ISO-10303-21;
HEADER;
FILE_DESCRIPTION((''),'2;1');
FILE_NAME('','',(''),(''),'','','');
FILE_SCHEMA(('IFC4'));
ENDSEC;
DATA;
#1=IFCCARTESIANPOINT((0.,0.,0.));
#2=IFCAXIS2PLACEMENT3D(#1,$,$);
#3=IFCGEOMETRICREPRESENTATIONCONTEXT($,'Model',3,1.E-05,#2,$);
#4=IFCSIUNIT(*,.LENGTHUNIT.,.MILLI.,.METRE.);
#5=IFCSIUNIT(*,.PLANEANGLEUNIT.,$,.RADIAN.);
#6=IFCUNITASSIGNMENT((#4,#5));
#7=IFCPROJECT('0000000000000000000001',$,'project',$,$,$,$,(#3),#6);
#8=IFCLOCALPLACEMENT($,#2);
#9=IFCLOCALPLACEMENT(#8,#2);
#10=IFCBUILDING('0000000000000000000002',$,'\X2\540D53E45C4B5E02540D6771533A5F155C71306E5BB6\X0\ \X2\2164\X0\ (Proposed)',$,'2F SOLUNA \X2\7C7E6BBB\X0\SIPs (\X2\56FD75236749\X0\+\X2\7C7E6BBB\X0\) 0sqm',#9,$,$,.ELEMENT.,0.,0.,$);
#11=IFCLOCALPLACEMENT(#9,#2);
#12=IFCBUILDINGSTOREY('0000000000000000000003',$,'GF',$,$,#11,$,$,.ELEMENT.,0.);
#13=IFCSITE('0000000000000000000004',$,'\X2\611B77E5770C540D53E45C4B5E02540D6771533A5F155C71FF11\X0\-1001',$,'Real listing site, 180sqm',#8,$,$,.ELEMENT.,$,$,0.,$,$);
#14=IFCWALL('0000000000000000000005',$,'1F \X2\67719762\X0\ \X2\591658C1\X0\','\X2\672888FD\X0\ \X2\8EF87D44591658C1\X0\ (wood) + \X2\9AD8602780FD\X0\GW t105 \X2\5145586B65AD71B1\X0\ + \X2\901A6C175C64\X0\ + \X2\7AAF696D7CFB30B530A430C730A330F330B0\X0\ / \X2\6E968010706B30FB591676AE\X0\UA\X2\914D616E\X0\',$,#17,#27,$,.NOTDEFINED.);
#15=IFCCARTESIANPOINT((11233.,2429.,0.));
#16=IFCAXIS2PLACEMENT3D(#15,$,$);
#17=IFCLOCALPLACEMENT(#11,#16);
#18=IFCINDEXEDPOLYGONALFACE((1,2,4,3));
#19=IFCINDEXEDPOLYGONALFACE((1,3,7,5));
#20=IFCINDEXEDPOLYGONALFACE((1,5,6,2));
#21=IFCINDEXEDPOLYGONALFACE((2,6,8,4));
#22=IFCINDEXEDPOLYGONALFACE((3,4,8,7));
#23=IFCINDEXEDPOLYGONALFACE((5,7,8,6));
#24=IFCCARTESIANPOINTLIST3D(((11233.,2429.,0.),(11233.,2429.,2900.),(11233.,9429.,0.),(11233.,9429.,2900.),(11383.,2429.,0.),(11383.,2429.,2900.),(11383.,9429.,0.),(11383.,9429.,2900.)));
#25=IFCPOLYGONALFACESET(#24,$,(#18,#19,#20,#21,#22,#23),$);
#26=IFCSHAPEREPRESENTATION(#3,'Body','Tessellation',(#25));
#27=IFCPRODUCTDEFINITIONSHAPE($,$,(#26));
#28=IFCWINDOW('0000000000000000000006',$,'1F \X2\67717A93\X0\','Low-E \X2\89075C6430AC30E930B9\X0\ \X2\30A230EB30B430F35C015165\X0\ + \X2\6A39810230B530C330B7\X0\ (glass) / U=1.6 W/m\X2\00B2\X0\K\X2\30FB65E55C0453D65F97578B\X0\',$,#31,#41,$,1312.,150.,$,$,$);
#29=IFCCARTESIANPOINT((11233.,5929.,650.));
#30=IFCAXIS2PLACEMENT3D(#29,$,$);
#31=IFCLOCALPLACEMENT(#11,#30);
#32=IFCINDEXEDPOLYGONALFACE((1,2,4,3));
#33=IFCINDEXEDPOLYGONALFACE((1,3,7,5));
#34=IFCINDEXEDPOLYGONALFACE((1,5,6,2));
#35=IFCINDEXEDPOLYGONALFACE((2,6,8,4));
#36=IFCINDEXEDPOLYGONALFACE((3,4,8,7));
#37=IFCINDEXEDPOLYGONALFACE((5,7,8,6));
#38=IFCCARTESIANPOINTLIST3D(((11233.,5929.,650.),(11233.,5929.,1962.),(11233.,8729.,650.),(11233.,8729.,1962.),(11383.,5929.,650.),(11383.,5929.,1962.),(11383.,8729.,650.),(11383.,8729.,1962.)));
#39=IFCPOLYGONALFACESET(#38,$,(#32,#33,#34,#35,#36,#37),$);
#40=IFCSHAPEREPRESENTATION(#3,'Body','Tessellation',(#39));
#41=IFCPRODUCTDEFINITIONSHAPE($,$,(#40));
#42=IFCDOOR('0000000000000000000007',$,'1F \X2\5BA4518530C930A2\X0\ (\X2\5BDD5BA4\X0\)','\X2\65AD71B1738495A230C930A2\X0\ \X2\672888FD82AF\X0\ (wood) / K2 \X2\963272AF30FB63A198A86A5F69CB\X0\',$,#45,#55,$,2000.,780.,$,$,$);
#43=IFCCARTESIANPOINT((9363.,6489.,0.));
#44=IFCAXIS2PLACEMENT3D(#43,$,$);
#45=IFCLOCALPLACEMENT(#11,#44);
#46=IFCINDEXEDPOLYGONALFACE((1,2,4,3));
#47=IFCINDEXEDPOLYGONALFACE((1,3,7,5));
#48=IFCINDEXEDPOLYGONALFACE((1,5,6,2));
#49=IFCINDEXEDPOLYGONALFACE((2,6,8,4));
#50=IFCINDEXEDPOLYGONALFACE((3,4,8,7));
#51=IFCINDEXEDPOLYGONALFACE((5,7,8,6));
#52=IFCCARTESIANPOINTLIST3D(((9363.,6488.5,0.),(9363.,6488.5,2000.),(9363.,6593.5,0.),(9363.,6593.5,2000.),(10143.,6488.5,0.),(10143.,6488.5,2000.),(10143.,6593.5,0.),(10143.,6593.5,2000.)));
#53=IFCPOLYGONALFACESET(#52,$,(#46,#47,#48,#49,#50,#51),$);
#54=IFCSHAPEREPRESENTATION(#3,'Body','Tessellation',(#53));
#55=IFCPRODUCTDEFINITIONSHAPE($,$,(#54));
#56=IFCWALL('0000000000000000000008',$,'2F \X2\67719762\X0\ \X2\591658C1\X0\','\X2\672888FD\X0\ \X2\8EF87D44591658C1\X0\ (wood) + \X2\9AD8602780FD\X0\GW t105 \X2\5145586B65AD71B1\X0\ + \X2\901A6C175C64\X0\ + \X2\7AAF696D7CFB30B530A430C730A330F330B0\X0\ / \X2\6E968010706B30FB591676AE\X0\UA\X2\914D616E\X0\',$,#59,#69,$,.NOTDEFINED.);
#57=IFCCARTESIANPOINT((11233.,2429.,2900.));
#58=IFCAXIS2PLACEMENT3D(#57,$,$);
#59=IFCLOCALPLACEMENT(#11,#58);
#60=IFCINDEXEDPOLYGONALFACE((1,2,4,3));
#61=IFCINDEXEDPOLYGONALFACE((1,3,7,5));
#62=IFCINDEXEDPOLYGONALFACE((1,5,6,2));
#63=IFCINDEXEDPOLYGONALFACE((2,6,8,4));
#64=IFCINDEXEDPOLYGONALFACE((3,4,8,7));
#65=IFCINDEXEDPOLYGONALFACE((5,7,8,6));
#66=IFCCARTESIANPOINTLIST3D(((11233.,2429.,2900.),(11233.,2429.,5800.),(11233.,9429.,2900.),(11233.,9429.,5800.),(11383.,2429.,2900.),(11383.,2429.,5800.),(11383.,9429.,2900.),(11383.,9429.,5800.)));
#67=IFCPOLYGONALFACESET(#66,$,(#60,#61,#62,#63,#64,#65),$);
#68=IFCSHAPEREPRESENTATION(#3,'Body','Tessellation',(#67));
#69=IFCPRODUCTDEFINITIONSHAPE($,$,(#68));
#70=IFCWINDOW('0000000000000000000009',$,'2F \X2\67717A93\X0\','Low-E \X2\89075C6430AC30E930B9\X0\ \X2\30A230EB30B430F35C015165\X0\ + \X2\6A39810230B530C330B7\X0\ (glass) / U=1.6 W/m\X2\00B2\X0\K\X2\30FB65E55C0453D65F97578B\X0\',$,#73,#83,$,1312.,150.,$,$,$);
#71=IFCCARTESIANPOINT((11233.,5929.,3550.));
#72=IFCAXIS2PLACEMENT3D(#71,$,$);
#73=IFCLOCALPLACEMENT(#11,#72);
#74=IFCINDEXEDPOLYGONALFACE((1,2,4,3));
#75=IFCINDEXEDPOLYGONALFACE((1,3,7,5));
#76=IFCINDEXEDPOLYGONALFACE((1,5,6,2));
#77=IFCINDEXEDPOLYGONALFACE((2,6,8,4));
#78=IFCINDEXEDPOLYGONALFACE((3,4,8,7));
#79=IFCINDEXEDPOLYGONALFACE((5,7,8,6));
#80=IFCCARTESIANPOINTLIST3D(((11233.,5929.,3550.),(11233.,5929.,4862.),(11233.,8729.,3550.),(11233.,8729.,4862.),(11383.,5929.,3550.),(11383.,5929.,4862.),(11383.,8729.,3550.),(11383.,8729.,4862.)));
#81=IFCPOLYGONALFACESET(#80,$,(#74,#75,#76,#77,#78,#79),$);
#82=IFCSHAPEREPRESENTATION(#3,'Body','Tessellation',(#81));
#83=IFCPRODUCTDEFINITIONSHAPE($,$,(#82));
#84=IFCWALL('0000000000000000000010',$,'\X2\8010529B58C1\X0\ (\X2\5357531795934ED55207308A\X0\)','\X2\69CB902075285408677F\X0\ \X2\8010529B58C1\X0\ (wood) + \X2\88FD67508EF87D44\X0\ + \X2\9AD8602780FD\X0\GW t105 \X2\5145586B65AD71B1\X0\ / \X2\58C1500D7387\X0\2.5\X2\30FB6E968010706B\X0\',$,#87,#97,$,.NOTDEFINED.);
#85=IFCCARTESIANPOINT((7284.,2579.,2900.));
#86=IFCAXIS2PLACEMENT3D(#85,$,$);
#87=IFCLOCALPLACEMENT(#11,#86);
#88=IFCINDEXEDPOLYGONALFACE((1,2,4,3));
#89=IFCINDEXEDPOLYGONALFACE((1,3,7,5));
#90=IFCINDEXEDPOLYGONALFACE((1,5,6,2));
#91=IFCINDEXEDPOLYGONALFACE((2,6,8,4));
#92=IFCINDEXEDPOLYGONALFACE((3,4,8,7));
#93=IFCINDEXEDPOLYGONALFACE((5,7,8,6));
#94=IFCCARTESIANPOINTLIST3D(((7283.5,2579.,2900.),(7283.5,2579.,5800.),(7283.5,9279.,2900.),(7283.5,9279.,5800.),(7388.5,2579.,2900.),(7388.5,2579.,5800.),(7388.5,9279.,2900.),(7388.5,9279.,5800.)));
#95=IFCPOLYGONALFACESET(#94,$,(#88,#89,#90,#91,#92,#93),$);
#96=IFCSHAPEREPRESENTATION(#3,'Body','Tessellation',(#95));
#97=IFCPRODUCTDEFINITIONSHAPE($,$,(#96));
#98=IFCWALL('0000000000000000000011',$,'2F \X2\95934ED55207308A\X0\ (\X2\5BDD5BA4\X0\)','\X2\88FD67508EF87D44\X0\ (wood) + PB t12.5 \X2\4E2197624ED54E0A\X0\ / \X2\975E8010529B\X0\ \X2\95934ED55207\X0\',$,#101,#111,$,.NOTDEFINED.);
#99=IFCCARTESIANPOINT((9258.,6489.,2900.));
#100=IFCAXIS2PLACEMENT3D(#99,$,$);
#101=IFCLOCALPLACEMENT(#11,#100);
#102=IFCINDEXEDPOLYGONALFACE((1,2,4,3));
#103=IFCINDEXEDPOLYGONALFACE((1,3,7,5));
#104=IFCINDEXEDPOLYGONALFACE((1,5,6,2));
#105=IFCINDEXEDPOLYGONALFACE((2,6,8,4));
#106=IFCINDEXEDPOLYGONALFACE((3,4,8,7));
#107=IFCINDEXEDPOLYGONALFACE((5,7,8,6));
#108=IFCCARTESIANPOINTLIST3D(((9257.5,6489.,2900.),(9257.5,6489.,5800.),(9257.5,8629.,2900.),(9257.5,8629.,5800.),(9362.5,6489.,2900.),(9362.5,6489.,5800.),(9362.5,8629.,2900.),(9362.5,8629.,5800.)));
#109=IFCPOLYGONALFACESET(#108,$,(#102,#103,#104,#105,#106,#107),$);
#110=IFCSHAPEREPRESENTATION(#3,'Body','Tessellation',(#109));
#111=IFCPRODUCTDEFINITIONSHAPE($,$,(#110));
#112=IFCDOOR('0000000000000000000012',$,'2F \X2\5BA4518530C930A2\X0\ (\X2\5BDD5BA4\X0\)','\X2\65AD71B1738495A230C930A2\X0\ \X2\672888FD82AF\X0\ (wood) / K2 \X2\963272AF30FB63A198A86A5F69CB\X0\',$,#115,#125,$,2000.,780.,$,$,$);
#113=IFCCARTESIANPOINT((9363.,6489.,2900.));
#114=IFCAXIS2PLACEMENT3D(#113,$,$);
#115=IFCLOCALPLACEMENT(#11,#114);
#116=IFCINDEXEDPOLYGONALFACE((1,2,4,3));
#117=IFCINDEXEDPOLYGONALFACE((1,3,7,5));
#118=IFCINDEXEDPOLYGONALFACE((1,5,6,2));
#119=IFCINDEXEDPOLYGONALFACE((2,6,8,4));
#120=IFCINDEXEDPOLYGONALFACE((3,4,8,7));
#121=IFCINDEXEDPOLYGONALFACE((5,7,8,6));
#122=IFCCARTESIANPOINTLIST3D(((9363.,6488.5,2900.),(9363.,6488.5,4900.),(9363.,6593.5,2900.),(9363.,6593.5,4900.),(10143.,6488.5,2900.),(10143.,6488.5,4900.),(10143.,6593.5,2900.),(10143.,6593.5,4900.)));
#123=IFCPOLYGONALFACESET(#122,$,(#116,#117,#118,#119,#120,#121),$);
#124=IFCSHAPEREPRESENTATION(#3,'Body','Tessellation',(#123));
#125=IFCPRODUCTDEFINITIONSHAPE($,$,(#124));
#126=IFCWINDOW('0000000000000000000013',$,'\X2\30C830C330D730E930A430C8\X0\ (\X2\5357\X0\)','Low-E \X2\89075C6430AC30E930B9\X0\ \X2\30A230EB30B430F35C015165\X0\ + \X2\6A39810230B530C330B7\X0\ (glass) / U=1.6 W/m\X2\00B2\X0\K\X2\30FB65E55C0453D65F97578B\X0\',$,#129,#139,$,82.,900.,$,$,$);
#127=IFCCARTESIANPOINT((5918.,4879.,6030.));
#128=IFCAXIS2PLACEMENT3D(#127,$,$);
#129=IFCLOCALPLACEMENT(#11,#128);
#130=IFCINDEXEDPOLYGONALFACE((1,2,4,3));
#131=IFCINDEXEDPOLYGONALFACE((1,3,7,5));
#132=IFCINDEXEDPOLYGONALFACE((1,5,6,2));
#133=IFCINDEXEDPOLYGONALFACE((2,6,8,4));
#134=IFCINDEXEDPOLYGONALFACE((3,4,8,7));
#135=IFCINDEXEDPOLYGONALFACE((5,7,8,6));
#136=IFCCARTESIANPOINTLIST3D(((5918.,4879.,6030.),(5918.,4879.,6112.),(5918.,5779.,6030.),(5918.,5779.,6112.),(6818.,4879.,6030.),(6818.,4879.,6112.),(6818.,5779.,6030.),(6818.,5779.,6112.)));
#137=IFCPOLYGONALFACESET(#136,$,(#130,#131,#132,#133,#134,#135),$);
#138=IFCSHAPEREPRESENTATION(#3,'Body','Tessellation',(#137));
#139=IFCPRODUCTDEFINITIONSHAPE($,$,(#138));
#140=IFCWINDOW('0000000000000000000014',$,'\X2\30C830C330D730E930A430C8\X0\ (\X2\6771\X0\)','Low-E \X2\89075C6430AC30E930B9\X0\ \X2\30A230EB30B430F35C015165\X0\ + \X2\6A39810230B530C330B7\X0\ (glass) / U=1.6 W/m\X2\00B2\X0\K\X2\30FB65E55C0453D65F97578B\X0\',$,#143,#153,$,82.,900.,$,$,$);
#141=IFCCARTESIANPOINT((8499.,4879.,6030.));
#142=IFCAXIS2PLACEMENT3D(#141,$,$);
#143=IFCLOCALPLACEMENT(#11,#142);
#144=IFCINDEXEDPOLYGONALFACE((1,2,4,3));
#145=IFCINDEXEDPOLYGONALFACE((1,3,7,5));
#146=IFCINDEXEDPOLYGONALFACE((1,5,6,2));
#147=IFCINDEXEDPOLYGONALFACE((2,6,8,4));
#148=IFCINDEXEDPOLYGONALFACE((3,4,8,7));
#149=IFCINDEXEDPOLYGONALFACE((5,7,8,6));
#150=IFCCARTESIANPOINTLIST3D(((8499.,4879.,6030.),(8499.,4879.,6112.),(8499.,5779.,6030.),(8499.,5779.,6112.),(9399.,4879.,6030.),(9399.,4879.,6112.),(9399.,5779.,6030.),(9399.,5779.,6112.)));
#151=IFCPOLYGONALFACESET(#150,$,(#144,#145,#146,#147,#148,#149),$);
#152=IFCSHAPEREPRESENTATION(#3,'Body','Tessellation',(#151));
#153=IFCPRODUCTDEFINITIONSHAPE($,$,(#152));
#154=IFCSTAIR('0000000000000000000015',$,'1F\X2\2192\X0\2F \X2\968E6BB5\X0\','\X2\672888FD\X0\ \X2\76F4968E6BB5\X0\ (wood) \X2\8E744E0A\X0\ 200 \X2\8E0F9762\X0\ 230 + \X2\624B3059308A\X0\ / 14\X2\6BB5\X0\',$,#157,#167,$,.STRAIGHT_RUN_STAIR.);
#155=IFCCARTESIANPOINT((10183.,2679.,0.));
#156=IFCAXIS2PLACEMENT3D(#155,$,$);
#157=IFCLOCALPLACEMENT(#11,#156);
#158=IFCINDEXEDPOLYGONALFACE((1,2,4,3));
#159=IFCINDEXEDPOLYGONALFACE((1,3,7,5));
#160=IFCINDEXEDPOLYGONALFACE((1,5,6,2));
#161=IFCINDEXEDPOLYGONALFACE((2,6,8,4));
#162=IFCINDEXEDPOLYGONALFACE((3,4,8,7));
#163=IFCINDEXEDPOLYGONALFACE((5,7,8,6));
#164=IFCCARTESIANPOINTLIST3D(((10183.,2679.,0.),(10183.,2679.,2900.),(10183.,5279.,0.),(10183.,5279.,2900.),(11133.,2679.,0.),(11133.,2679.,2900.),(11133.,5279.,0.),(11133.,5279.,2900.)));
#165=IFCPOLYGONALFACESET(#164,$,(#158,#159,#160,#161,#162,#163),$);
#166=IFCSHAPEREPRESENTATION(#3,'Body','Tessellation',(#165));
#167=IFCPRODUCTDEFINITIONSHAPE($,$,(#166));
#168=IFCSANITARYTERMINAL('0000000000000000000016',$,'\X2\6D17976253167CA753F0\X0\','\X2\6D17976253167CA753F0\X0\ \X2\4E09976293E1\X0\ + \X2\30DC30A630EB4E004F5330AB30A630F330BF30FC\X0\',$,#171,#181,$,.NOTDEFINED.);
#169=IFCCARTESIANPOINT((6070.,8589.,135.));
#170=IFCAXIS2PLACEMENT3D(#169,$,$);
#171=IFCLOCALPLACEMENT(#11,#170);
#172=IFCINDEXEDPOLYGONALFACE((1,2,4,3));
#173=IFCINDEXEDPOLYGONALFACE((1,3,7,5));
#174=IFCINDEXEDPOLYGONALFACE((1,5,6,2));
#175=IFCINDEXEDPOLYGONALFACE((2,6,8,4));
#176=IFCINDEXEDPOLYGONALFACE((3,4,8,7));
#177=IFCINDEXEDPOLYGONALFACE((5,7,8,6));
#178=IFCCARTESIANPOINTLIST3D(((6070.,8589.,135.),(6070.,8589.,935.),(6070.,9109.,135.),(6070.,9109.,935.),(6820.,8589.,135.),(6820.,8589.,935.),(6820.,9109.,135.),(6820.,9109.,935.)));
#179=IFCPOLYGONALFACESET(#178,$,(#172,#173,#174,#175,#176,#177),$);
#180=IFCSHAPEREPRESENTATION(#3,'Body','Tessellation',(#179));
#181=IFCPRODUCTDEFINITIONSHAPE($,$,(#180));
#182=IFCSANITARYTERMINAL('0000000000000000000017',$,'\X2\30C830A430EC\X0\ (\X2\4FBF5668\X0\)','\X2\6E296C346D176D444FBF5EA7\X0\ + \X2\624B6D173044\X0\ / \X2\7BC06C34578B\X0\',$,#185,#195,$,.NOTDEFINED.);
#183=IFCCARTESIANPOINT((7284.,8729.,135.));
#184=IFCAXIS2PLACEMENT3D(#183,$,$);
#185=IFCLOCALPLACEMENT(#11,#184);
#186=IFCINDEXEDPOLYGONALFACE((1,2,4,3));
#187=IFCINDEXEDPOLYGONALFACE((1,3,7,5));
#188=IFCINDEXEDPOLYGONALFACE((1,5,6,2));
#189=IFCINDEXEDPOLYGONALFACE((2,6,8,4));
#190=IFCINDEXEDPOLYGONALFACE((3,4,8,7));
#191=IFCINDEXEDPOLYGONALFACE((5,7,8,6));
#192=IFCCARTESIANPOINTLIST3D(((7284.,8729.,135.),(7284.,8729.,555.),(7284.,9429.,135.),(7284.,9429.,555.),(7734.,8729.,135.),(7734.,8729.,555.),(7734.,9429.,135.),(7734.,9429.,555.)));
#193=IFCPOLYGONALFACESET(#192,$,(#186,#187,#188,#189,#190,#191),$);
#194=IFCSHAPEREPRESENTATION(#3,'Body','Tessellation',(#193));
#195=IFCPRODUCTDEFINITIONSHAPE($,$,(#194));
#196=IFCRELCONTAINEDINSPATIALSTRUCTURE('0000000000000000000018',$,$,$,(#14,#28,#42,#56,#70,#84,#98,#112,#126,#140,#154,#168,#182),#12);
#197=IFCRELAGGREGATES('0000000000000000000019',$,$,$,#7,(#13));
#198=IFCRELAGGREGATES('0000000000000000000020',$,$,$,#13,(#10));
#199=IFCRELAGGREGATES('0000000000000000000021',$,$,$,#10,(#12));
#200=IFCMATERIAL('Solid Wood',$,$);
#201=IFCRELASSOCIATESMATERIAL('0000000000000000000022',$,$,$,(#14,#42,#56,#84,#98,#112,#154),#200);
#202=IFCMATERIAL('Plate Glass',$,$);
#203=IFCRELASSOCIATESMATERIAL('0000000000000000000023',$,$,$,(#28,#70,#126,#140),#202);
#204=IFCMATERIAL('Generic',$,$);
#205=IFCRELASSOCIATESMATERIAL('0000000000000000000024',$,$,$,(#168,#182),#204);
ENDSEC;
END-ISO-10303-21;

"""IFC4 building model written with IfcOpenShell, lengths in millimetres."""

from ifc_helpers import new_model, si_unit, frame, frame_2d, origin, place, context, project, spatial, rectangle, extrude, material, element, fill, save


model = new_model("IFC4")

# Units and contexts
model_context = context("Model", 3, precision=1e-05, world=origin())
ifc_project = project(units=[si_unit("LENGTHUNIT", "METRE", prefix="MILLI"), si_unit("PLANEANGLEUNIT", "RADIAN")], contexts=[model_context])

# Site, building, storey
site_placement = place(None, origin())
site = spatial("IfcSite", under=ifc_project, at=site_placement, Name="愛知県名古屋市名東区引山１-1001", ObjectType="Real listing site, 180sqm", CompositionType="ELEMENT", RefElevation=0.0)
building_placement = place(site_placement, origin())
building = spatial("IfcBuilding", under=site, at=building_placement, Name="名古屋市名東区引山の家 Ⅴ (Proposed)", ObjectType="2F SOLUNA 籾殻SIPs (国産杉+籾殻) 0sqm", CompositionType="ELEMENT", ElevationOfRefHeight=0.0, ElevationOfTerrain=0.0)
storey_placement = place(building_placement, origin())
storey = spatial("IfcBuildingStorey", under=building, at=storey_placement, Name="GF", CompositionType="ELEMENT", Elevation=0.0)

# Wall, opening, window
ifc_material_1 = material(Name="Solid Wood")
wall_1_placement = place(storey_placement, frame((11233.0, 2429.0, 0.0)))
wall_1 = element("IfcWall", 1, at=wall_1_placement, inside=storey, material=ifc_material_1, Name="1F 東面 外壁", Description="木製 軸組外壁 (wood) + 高性能GW t105 充填断熱 + 通気層 + 窯業系サイディング / 準耐火・外皮UA配慮", PredefinedType="NOTDEFINED", context=model_context, shape_type="SweptSolid", body=[
    extrude(rectangle(XDim=150.0, YDim=7000.0, at=frame_2d((75.0, 3500.0))), frame((11233.0, 2429.0, 0.0)), (0.0, 0.0, 1.0), 2900.0),
])
opening_1_placement = place(storey_placement, frame((11233.0, 5929.0, 650.0)))
opening_1 = element("IfcOpeningElement", 2, at=opening_1_placement, cuts=wall_1, PredefinedType="NOTDEFINED", context=model_context, shape_type="SweptSolid", body=[
    extrude(rectangle(XDim=150.0, YDim=2800.0, at=frame_2d((75.0, 1400.0))), frame((11233.0, 5929.0, 650.0)), (0.0, 0.0, 1.0), 1312.0),
])
ifc_material_2 = material(Name="Plate Glass")
window_1_placement = place(storey_placement, frame((11233.0, 5929.0, 650.0)))
window_1 = element("IfcWindow", 3, at=window_1_placement, inside=storey, material=ifc_material_2, Name="1F 東窓", Description="Low-E 複層ガラス アルゴン封入 + 樹脂サッシ (glass) / U=1.6 W/m²K・日射取得型", OverallHeight=1312.0, OverallWidth=150.0, context=model_context, shape_type="SweptSolid", body=[
    extrude(rectangle(XDim=150.0, YDim=2800.0, at=frame_2d((75.0, 1400.0))), frame((11233.0, 5929.0, 650.0)), (0.0, 0.0, 1.0), 1312.0),
])
fill(opening_1, window_1)

# Door
door_1_placement = place(storey_placement, frame((9363.0, 6489.0, 0.0)))
element("IfcDoor", 4, at=door_1_placement, inside=storey, material=ifc_material_1, Name="1F 室内ドア (寝室)", Description="断熱玄関ドア 木製芯 (wood) / K2 防犯・採風機構", OverallHeight=2000.0, OverallWidth=780.0, context=model_context, shape_type="SweptSolid", body=[
    extrude(rectangle(XDim=780.0, YDim=105.0, at=frame_2d((390.0, 52.0))), frame((9363.0, 6489.0, 0.0)), (0.0, 0.0, 1.0), 2000.0),
])

# Wall, opening, window
wall_2_placement = place(storey_placement, frame((11233.0, 2429.0, 2900.0)))
wall_2 = element("IfcWall", 5, at=wall_2_placement, inside=storey, material=ifc_material_1, Name="2F 東面 外壁", Description="木製 軸組外壁 (wood) + 高性能GW t105 充填断熱 + 通気層 + 窯業系サイディング / 準耐火・外皮UA配慮", PredefinedType="NOTDEFINED", context=model_context, shape_type="SweptSolid", body=[
    extrude(rectangle(XDim=150.0, YDim=7000.0, at=frame_2d((75.0, 3500.0))), frame((11233.0, 2429.0, 2900.0)), (0.0, 0.0, 1.0), 2900.0),
])
opening_2_placement = place(storey_placement, frame((11233.0, 5929.0, 3550.0)))
opening_2 = element("IfcOpeningElement", 6, at=opening_2_placement, cuts=wall_2, PredefinedType="NOTDEFINED", context=model_context, shape_type="SweptSolid", body=[
    extrude(rectangle(XDim=150.0, YDim=2800.0, at=frame_2d((75.0, 1400.0))), frame((11233.0, 5929.0, 3550.0)), (0.0, 0.0, 1.0), 1312.0),
])
window_2_placement = place(storey_placement, frame((11233.0, 5929.0, 3550.0)))
window_2 = element("IfcWindow", 7, at=window_2_placement, inside=storey, material=ifc_material_2, Name="2F 東窓", Description="Low-E 複層ガラス アルゴン封入 + 樹脂サッシ (glass) / U=1.6 W/m²K・日射取得型", OverallHeight=1312.0, OverallWidth=150.0, context=model_context, shape_type="SweptSolid", body=[
    extrude(rectangle(XDim=150.0, YDim=2800.0, at=frame_2d((75.0, 1400.0))), frame((11233.0, 5929.0, 3550.0)), (0.0, 0.0, 1.0), 1312.0),
])
fill(opening_2, window_2)

# Walls
wall_3_placement = place(storey_placement, frame((7284.0, 2579.0, 2900.0)))
element("IfcWall", 8, at=wall_3_placement, inside=storey, material=ifc_material_1, Name="耐力壁 (南北間仕切り)", Description="構造用合板 耐力壁 (wood) + 製材軸組 + 高性能GW t105 充填断熱 / 壁倍率2.5・準耐火", PredefinedType="NOTDEFINED", context=model_context, shape_type="SweptSolid", body=[
    extrude(rectangle(XDim=105.0, YDim=6700.0, at=frame_2d((52.0, 3350.0))), frame((7284.0, 2579.0, 2900.0)), (0.0, 0.0, 1.0), 2900.0),
])
wall_4_placement = place(storey_placement, frame((9258.0, 6489.0, 2900.0)))
element("IfcWall", 9, at=wall_4_placement, inside=storey, material=ifc_material_1, Name="2F 間仕切り (寝室)", Description="製材軸組 (wood) + PB t12.5 両面仕上 / 非耐力 間仕切", PredefinedType="NOTDEFINED", context=model_context, shape_type="SweptSolid", body=[
    extrude(rectangle(XDim=105.0, YDim=2140.0, at=frame_2d((52.0, 1070.0))), frame((9258.0, 6489.0, 2900.0)), (0.0, 0.0, 1.0), 2900.0),
])

# Door
door_2_placement = place(storey_placement, frame((9363.0, 6489.0, 2900.0)))
element("IfcDoor", 10, at=door_2_placement, inside=storey, material=ifc_material_1, Name="2F 室内ドア (寝室)", Description="断熱玄関ドア 木製芯 (wood) / K2 防犯・採風機構", OverallHeight=2000.0, OverallWidth=780.0, context=model_context, shape_type="SweptSolid", body=[
    extrude(rectangle(XDim=780.0, YDim=105.0, at=frame_2d((390.0, 52.0))), frame((9363.0, 6489.0, 2900.0)), (0.0, 0.0, 1.0), 2000.0),
])

# Windows
window_3_placement = place(storey_placement, frame((5918.0, 4879.0, 6030.0)))
element("IfcWindow", 11, at=window_3_placement, inside=storey, material=ifc_material_2, Name="トップライト (南)", Description="Low-E 複層ガラス アルゴン封入 + 樹脂サッシ (glass) / U=1.6 W/m²K・日射取得型", OverallHeight=82.0, OverallWidth=900.0, context=model_context, shape_type="SweptSolid", body=[
    extrude(rectangle(XDim=900.0, YDim=900.0, at=frame_2d((450.0, 450.0))), frame((5918.0, 4879.0, 6030.0)), (0.0, 0.0, 1.0), 82.0),
])
window_4_placement = place(storey_placement, frame((8499.0, 4879.0, 6030.0)))
element("IfcWindow", 12, at=window_4_placement, inside=storey, material=ifc_material_2, Name="トップライト (東)", Description="Low-E 複層ガラス アルゴン封入 + 樹脂サッシ (glass) / U=1.6 W/m²K・日射取得型", OverallHeight=82.0, OverallWidth=900.0, context=model_context, shape_type="SweptSolid", body=[
    extrude(rectangle(XDim=900.0, YDim=900.0, at=frame_2d((450.0, 450.0))), frame((8499.0, 4879.0, 6030.0)), (0.0, 0.0, 1.0), 82.0),
])

# Stair
stair_placement = place(storey_placement, frame((10183.0, 2679.0, 0.0)))
element("IfcStair", 13, at=stair_placement, inside=storey, material=ifc_material_1, Name="1F→2F 階段", Description="木製 直階段 (wood) 蹴上 200 踏面 230 + 手すり / 14段", PredefinedType="STRAIGHT_RUN_STAIR", context=model_context, shape_type="SweptSolid", body=[
    extrude(rectangle(XDim=950.0, YDim=2600.0, at=frame_2d((475.0, 1300.0))), frame((10183.0, 2679.0, 0.0)), (0.0, 0.0, 1.0), 2900.0),
])

# Sanitary terminals
ifc_material_3 = material(Name="Generic")
sanitary_terminal_1_placement = place(storey_placement, frame((6070.0, 8589.0, 135.0)))
element("IfcSanitaryTerminal", 14, at=sanitary_terminal_1_placement, inside=storey, material=ifc_material_3, Name="洗面化粧台", Description="洗面化粧台 三面鏡 + ボウル一体カウンター", PredefinedType="NOTDEFINED", context=model_context, shape_type="SweptSolid", body=[
    extrude(rectangle(XDim=750.0, YDim=520.0, at=frame_2d((375.0, 260.0))), frame((6070.0, 8589.0, 135.0)), (0.0, 0.0, 1.0), 800.0),
])
sanitary_terminal_2_placement = place(storey_placement, frame((7284.0, 8729.0, 135.0)))
element("IfcSanitaryTerminal", 15, at=sanitary_terminal_2_placement, inside=storey, material=ifc_material_3, Name="トイレ (便器)", Description="温水洗浄便座 + 手洗い / 節水型", PredefinedType="NOTDEFINED", context=model_context, shape_type="SweptSolid", body=[
    extrude(rectangle(XDim=450.0, YDim=700.0, at=frame_2d((225.0, 350.0))), frame((7284.0, 8729.0, 135.0)), (0.0, 0.0, 1.0), 420.0),
])

save(model, "model.ifc")
